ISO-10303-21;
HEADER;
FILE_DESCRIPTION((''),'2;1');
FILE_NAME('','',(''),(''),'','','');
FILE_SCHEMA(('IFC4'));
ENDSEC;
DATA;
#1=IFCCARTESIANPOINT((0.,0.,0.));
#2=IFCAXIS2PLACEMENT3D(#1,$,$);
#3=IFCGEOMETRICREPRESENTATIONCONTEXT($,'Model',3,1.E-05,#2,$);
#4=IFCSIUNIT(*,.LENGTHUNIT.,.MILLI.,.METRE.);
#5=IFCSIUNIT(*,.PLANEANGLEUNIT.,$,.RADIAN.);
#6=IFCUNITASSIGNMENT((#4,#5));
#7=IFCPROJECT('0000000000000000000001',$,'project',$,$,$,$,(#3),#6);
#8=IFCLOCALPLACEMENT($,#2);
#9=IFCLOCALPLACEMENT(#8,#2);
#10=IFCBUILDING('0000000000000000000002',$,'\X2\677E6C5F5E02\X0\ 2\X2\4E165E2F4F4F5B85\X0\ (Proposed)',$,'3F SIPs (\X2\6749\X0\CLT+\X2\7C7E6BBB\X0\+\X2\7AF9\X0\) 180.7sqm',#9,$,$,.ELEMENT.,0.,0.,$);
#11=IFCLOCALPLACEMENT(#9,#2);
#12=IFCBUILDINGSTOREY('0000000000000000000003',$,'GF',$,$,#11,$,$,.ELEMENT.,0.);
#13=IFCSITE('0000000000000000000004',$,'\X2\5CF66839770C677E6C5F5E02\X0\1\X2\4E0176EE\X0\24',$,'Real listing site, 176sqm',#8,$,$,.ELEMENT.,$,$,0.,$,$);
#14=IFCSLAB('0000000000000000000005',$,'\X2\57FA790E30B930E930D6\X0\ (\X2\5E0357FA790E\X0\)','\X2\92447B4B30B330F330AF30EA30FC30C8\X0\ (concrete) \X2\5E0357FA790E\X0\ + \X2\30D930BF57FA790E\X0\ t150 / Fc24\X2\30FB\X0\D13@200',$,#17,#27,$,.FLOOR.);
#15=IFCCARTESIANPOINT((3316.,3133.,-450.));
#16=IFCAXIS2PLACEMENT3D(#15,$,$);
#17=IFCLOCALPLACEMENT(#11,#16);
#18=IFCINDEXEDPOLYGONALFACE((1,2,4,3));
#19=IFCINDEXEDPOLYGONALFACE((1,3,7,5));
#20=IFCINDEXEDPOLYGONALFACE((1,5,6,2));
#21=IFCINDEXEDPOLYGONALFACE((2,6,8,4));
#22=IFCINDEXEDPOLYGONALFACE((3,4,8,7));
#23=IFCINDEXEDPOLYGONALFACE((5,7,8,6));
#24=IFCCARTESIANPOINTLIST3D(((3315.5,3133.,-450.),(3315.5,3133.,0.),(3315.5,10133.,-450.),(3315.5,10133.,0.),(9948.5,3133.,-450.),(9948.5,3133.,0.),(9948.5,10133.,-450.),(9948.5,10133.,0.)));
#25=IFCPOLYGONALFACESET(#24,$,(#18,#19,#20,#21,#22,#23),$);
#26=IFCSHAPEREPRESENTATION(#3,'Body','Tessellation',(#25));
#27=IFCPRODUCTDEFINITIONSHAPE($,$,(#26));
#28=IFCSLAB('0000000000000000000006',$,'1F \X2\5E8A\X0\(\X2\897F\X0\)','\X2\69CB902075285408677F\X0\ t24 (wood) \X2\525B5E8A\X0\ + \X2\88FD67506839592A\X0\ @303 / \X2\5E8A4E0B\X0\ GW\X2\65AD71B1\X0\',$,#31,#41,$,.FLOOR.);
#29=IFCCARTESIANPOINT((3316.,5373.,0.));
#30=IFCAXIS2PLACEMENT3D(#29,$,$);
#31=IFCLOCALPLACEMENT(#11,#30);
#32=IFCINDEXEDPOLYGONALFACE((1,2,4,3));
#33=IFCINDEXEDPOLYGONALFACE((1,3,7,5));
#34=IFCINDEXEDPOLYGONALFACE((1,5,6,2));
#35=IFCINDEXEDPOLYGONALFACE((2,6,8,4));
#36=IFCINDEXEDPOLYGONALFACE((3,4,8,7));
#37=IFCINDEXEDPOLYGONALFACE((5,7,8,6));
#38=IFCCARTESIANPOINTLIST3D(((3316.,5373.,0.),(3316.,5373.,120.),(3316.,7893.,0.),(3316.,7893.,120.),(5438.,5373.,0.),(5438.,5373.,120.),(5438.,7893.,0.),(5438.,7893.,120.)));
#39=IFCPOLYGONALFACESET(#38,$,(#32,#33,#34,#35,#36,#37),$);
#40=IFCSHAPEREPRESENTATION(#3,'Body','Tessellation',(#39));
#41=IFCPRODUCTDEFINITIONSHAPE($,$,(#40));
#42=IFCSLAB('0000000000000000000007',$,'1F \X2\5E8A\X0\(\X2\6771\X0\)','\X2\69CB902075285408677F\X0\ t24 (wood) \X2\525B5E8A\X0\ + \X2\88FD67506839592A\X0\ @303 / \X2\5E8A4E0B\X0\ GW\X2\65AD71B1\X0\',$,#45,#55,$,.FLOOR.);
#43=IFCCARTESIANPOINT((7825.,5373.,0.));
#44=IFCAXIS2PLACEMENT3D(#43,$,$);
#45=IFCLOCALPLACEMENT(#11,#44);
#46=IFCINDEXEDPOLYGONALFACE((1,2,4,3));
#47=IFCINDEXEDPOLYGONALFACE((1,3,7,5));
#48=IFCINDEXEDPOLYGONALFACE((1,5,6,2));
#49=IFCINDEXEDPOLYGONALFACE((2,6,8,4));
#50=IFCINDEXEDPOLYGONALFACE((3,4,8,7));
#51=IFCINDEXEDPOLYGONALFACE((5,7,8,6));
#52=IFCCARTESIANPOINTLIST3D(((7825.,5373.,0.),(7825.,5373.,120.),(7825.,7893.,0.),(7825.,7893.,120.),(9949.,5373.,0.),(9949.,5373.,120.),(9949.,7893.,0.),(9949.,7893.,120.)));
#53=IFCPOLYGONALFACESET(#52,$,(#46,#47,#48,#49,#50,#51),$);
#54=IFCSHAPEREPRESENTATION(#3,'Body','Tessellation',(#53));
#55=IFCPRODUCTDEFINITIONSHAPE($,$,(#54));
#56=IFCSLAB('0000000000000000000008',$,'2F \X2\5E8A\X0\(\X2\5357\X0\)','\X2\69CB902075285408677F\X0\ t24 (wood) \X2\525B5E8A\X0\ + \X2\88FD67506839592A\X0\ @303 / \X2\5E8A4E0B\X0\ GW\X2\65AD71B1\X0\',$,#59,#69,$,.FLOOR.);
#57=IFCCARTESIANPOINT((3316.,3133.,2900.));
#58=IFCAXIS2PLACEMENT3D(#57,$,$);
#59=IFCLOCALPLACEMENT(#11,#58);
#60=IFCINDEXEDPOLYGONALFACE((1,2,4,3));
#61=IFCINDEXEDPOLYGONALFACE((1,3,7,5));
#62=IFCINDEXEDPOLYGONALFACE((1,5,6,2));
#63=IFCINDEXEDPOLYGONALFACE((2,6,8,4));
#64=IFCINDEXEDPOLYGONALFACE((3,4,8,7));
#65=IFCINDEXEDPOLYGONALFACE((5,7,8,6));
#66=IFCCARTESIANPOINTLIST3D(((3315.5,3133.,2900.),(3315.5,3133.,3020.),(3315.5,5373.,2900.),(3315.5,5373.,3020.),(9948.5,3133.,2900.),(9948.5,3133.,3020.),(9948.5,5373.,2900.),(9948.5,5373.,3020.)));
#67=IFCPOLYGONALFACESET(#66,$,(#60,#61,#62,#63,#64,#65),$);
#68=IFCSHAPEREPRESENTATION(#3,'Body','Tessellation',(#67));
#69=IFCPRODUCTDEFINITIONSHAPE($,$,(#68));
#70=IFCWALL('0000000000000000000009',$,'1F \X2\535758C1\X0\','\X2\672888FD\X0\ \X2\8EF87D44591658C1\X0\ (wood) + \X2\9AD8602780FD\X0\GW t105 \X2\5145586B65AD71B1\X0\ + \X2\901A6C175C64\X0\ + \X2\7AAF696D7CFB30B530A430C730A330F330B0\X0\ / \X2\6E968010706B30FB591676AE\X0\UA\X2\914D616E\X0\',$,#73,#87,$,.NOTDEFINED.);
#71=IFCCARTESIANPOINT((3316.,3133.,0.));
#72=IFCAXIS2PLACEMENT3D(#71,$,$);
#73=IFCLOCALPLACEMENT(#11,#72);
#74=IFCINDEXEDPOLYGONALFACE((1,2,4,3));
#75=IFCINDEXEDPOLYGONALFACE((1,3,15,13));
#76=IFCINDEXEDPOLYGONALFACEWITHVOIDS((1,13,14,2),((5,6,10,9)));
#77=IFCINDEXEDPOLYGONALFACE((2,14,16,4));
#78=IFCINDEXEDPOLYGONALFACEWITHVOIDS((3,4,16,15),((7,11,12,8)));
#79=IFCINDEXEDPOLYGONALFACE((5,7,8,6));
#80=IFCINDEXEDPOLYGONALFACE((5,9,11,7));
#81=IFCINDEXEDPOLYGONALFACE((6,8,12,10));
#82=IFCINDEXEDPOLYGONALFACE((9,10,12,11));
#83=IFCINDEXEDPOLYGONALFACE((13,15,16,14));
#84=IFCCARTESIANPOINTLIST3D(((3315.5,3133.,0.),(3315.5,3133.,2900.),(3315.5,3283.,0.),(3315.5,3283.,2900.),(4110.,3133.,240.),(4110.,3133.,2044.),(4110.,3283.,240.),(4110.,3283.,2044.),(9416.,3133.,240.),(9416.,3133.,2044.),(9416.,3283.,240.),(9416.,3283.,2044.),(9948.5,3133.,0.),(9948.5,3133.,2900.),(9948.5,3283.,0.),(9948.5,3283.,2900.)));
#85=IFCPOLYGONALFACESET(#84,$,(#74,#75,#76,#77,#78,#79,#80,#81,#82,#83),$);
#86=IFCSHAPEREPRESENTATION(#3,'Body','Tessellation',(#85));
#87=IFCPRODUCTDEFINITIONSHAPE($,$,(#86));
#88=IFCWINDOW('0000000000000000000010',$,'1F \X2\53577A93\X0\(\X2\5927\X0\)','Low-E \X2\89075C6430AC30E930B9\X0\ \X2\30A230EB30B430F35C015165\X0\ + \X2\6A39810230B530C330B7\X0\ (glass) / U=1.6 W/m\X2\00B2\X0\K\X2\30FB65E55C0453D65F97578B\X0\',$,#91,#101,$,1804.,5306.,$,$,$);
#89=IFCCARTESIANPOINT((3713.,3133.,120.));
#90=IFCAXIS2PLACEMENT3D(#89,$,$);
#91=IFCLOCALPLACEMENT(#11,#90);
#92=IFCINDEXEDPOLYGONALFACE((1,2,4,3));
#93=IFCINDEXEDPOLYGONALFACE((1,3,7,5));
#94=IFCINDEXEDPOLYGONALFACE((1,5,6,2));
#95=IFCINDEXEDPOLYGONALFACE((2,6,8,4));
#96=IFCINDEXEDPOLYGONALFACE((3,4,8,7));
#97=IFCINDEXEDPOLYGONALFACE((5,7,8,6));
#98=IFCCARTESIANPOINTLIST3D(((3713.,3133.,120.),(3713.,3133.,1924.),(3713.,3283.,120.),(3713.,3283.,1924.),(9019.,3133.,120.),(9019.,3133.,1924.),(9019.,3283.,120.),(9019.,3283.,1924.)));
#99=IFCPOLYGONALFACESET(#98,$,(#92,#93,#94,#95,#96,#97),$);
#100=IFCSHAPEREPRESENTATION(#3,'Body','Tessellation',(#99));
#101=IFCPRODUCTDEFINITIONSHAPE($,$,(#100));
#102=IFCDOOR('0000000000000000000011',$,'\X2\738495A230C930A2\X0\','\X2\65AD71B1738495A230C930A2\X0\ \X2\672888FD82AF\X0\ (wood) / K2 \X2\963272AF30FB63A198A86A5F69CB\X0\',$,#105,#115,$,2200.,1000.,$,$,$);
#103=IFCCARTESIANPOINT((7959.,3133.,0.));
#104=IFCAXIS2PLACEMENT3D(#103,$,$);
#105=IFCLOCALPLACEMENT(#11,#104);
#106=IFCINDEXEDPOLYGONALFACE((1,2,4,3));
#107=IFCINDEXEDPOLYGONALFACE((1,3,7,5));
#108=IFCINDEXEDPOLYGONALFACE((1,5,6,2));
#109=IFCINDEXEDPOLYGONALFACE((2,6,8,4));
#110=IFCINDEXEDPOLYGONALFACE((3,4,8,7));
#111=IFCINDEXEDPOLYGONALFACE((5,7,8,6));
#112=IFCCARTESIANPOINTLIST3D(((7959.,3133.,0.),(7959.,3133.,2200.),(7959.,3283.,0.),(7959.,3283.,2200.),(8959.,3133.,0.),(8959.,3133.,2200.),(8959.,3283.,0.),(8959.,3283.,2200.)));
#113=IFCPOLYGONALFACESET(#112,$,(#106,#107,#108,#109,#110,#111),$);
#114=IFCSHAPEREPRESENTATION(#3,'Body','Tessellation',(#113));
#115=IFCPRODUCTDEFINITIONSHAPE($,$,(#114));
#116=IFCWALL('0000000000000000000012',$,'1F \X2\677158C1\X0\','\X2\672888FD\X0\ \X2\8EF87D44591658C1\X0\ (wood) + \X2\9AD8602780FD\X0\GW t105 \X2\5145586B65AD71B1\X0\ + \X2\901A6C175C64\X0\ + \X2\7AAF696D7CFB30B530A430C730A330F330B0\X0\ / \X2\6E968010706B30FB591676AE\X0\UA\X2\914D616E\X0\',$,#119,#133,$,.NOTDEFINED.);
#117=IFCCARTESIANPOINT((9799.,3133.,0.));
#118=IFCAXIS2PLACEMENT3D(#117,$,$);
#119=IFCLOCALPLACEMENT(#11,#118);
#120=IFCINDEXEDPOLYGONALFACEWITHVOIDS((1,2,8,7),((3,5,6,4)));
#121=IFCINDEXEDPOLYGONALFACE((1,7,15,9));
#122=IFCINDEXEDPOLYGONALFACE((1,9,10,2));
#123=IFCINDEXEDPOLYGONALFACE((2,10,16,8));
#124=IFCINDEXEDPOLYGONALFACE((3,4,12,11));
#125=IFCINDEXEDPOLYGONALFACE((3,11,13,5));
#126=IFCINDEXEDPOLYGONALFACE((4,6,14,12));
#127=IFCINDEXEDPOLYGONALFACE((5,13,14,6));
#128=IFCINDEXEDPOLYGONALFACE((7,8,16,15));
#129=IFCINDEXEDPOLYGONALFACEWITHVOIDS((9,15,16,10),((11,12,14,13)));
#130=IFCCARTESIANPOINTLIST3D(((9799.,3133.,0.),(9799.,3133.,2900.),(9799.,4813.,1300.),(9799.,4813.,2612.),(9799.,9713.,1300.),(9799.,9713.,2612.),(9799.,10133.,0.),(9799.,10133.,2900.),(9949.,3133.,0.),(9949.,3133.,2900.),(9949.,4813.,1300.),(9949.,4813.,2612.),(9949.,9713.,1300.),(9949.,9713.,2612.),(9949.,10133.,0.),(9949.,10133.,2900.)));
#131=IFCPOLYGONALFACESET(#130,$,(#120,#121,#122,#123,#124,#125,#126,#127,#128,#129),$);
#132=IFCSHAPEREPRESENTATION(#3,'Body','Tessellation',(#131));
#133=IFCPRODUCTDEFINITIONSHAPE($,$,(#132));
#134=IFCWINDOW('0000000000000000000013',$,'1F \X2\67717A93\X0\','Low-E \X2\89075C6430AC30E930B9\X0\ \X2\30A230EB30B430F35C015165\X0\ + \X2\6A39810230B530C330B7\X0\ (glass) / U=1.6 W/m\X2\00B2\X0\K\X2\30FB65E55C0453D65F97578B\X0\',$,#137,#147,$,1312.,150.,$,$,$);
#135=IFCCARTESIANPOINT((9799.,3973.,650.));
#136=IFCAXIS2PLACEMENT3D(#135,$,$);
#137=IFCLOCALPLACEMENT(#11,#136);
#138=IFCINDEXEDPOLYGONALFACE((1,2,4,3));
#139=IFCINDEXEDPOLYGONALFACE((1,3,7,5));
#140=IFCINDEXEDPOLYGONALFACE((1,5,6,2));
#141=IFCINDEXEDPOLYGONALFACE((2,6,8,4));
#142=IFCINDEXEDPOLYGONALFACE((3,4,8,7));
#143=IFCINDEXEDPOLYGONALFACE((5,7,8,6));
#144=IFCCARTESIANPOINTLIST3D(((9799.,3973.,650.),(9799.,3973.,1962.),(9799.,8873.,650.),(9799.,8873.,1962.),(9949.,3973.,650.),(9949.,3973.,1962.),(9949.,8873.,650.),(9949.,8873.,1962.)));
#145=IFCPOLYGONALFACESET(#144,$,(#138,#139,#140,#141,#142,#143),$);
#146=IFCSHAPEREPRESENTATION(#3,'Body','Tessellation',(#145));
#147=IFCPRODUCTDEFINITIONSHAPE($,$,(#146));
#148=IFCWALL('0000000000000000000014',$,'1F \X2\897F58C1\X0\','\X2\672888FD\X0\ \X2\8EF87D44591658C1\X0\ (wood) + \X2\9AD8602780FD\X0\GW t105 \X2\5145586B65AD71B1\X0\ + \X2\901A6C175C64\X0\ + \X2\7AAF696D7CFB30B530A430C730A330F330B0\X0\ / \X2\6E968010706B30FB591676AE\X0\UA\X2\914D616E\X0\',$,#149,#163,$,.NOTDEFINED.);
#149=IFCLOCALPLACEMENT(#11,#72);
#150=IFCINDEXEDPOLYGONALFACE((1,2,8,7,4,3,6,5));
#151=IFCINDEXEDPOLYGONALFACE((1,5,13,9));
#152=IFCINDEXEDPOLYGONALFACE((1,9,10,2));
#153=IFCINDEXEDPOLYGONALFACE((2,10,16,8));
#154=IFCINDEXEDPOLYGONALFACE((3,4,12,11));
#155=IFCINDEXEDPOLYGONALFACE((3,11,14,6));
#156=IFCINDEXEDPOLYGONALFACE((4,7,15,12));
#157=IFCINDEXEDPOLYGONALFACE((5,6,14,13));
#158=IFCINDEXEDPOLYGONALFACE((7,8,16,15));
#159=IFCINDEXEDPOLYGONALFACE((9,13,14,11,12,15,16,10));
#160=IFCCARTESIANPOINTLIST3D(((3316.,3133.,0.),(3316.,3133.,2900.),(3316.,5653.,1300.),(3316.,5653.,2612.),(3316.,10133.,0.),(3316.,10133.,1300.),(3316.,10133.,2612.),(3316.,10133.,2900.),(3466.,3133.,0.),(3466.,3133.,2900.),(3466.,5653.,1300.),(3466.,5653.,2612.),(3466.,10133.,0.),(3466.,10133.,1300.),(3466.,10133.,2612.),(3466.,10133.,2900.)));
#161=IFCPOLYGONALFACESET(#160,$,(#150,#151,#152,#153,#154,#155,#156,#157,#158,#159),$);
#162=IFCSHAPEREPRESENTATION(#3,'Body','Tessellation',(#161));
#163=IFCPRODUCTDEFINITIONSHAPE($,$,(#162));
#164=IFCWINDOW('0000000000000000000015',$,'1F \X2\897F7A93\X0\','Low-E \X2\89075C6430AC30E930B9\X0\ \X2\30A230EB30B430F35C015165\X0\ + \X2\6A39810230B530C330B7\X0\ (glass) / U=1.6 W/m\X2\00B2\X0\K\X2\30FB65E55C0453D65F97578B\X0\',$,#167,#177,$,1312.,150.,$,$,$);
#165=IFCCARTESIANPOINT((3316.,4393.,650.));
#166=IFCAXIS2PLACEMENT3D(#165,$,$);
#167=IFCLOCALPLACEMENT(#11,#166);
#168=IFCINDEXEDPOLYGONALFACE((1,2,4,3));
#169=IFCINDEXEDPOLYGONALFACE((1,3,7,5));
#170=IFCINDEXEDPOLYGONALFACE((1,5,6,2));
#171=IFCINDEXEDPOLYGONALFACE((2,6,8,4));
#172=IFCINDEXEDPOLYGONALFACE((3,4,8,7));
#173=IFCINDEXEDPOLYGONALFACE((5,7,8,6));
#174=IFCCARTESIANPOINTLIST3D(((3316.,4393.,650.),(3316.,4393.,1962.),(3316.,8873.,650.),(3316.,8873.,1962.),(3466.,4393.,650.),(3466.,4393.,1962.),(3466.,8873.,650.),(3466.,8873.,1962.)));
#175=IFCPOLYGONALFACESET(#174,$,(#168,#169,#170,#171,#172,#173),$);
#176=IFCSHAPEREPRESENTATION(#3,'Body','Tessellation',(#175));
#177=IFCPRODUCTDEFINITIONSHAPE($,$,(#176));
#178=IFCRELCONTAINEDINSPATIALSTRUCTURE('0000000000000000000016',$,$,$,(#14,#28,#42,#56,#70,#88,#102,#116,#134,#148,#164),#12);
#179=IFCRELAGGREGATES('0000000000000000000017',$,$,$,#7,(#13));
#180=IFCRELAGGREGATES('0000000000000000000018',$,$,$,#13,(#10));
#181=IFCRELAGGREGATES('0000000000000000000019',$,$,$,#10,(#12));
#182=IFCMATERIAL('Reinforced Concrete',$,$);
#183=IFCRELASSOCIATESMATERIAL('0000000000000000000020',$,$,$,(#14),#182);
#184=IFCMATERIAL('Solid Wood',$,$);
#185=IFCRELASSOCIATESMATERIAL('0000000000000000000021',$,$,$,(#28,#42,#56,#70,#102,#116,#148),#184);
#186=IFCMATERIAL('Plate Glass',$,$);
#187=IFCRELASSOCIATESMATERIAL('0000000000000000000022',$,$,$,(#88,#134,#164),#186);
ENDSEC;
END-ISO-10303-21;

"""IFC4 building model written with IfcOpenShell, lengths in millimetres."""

from ifc_helpers import new_model, si_unit, frame, frame_2d, origin, place, context, project, spatial, rectangle, extrude, material, element, fill, save


model = new_model("IFC4")

# Units and contexts
model_context = context("Model", 3, precision=1e-05, world=origin())
ifc_project = project(units=[si_unit("LENGTHUNIT", "METRE", prefix="MILLI"), si_unit("PLANEANGLEUNIT", "RADIAN")], contexts=[model_context])

# Site, building, storey
site_placement = place(None, origin())
site = spatial("IfcSite", under=ifc_project, at=site_placement, Name="島根県松江市1丁目24", ObjectType="Real listing site, 176sqm", CompositionType="ELEMENT", RefElevation=0.0)
building_placement = place(site_placement, origin())
building = spatial("IfcBuilding", under=site, at=building_placement, Name="松江市 2世帯住宅 (Proposed)", ObjectType="3F SIPs (杉CLT+籾殻+竹) 180.7sqm", CompositionType="ELEMENT", ElevationOfRefHeight=0.0, ElevationOfTerrain=0.0)
storey_placement = place(building_placement, origin())
storey = spatial("IfcBuildingStorey", under=building, at=storey_placement, Name="GF", CompositionType="ELEMENT", Elevation=0.0)

# Slabs
ifc_material_1 = material(Name="Reinforced Concrete")
slab_1_placement = place(storey_placement, frame((3316.0, 3133.0, -450.0)))
element("IfcSlab", 1, at=slab_1_placement, inside=storey, material=ifc_material_1, Name="基礎スラブ (布基礎)", Description="鉄筋コンクリート (concrete) 布基礎 + ベタ基礎 t150 / Fc24・D13@200", PredefinedType="FLOOR", context=model_context, shape_type="SweptSolid", body=[
    extrude(rectangle(XDim=6633.0, YDim=7000.0, at=frame_2d((3316.0, 3500.0))), frame((3316.0, 3133.0, -450.0)), (0.0, 0.0, 1.0), 450.0),
])
ifc_material_2 = material(Name="Solid Wood")
slab_2_placement = place(storey_placement, frame((3316.0, 5373.0, 0.0)))
element("IfcSlab", 2, at=slab_2_placement, inside=storey, material=ifc_material_2, Name="1F 床(西)", Description="構造用合板 t24 (wood) 剛床 + 製材根太 @303 / 床下 GW断熱", PredefinedType="FLOOR", context=model_context, shape_type="SweptSolid", body=[
    extrude(rectangle(XDim=2122.0, YDim=2520.0, at=frame_2d((1061.0, 1260.0))), frame((3316.0, 5373.0, 0.0)), (0.0, 0.0, 1.0), 120.0),
])
slab_3_placement = place(storey_placement, frame((7825.0, 5373.0, 0.0)))
element("IfcSlab", 3, at=slab_3_placement, inside=storey, material=ifc_material_2, Name="1F 床(東)", Description="構造用合板 t24 (wood) 剛床 + 製材根太 @303 / 床下 GW断熱", PredefinedType="FLOOR", context=model_context, shape_type="SweptSolid", body=[
    extrude(rectangle(XDim=2124.0, YDim=2520.0, at=frame_2d((1062.0, 1260.0))), frame((7825.0, 5373.0, 0.0)), (0.0, 0.0, 1.0), 120.0),
])
slab_4_placement = place(storey_placement, frame((3316.0, 3133.0, 2900.0)))
element("IfcSlab", 4, at=slab_4_placement, inside=storey, material=ifc_material_2, Name="2F 床(南)", Description="構造用合板 t24 (wood) 剛床 + 製材根太 @303 / 床下 GW断熱", PredefinedType="FLOOR", context=model_context, shape_type="SweptSolid", body=[
    extrude(rectangle(XDim=6633.0, YDim=2240.0, at=frame_2d((3316.0, 1120.0))), frame((3316.0, 3133.0, 2900.0)), (0.0, 0.0, 1.0), 120.0),
])

# Wall, openings, window, door
wall_1_placement = place(storey_placement, frame((3316.0, 3133.0, 0.0)))
wall_1 = element("IfcWall", 5, at=wall_1_placement, inside=storey, material=ifc_material_2, Name="1F 南壁", Description="木製 軸組外壁 (wood) + 高性能GW t105 充填断熱 + 通気層 + 窯業系サイディング / 準耐火・外皮UA配慮", PredefinedType="NOTDEFINED", context=model_context, shape_type="SweptSolid", body=[
    extrude(rectangle(XDim=6633.0, YDim=150.0, at=frame_2d((3316.0, 75.0))), frame((3316.0, 3133.0, 0.0)), (0.0, 0.0, 1.0), 2900.0),
])
opening_1_placement = place(storey_placement, frame((3713.0, 3133.0, 120.0)))
opening_1 = element("IfcOpeningElement", 6, at=opening_1_placement, cuts=wall_1, PredefinedType="NOTDEFINED", context=model_context, shape_type="SweptSolid", body=[
    extrude(rectangle(XDim=5306.0, YDim=150.0, at=frame_2d((2653.0, 75.0))), frame((3713.0, 3133.0, 120.0)), (0.0, 0.0, 1.0), 1804.0),
])
opening_2_placement = place(storey_placement, frame((7959.0, 3133.0, 0.0)))
opening_2 = element("IfcOpeningElement", 7, at=opening_2_placement, cuts=wall_1, PredefinedType="NOTDEFINED", context=model_context, shape_type="SweptSolid", body=[
    extrude(rectangle(XDim=1000.0, YDim=150.0, at=frame_2d((500.0, 75.0))), frame((7959.0, 3133.0, 0.0)), (0.0, 0.0, 1.0), 2200.0),
])
ifc_material_3 = material(Name="Plate Glass")
window_1_placement = place(storey_placement, frame((3713.0, 3133.0, 120.0)))
window_1 = element("IfcWindow", 8, at=window_1_placement, inside=storey, material=ifc_material_3, Name="1F 南窓(大)", Description="Low-E 複層ガラス アルゴン封入 + 樹脂サッシ (glass) / U=1.6 W/m²K・日射取得型", OverallHeight=1804.0, OverallWidth=5306.0, context=model_context, shape_type="SweptSolid", body=[
    extrude(rectangle(XDim=5306.0, YDim=150.0, at=frame_2d((2653.0, 75.0))), frame((3713.0, 3133.0, 120.0)), (0.0, 0.0, 1.0), 1804.0),
])
fill(opening_1, window_1)
door_placement = place(storey_placement, frame((7959.0, 3133.0, 0.0)))
door = element("IfcDoor", 9, at=door_placement, inside=storey, material=ifc_material_2, Name="玄関ドア", Description="断熱玄関ドア 木製芯 (wood) / K2 防犯・採風機構", OverallHeight=2200.0, OverallWidth=1000.0, context=model_context, shape_type="SweptSolid", body=[
    extrude(rectangle(XDim=1000.0, YDim=150.0, at=frame_2d((500.0, 75.0))), frame((7959.0, 3133.0, 0.0)), (0.0, 0.0, 1.0), 2200.0),
])
fill(opening_2, door)

# Walls, openings, windows
wall_2_placement = place(storey_placement, frame((9799.0, 3133.0, 0.0)))
wall_2 = element("IfcWall", 10, at=wall_2_placement, inside=storey, material=ifc_material_2, Name="1F 東壁", Description="木製 軸組外壁 (wood) + 高性能GW t105 充填断熱 + 通気層 + 窯業系サイディング / 準耐火・外皮UA配慮", PredefinedType="NOTDEFINED", context=model_context, shape_type="SweptSolid", body=[
    extrude(rectangle(XDim=150.0, YDim=7000.0, at=frame_2d((75.0, 3500.0))), frame((9799.0, 3133.0, 0.0)), (0.0, 0.0, 1.0), 2900.0),
])
opening_3_placement = place(storey_placement, frame((9799.0, 3973.0, 650.0)))
opening_3 = element("IfcOpeningElement", 11, at=opening_3_placement, cuts=wall_2, PredefinedType="NOTDEFINED", context=model_context, shape_type="SweptSolid", body=[
    extrude(rectangle(XDim=150.0, YDim=4900.0, at=frame_2d((75.0, 2450.0))), frame((9799.0, 3973.0, 650.0)), (0.0, 0.0, 1.0), 1312.0),
])
window_2_placement = place(storey_placement, frame((9799.0, 3973.0, 650.0)))
window_2 = element("IfcWindow", 12, at=window_2_placement, inside=storey, material=ifc_material_3, Name="1F 東窓", Description="Low-E 複層ガラス アルゴン封入 + 樹脂サッシ (glass) / U=1.6 W/m²K・日射取得型", OverallHeight=1312.0, OverallWidth=150.0, context=model_context, shape_type="SweptSolid", body=[
    extrude(rectangle(XDim=150.0, YDim=4900.0, at=frame_2d((75.0, 2450.0))), frame((9799.0, 3973.0, 650.0)), (0.0, 0.0, 1.0), 1312.0),
])
fill(opening_3, window_2)
wall_3_placement = place(storey_placement, frame((3316.0, 3133.0, 0.0)))
wall_3 = element("IfcWall", 13, at=wall_3_placement, inside=storey, material=ifc_material_2, Name="1F 西壁", Description="木製 軸組外壁 (wood) + 高性能GW t105 充填断熱 + 通気層 + 窯業系サイディング / 準耐火・外皮UA配慮", PredefinedType="NOTDEFINED", context=model_context, shape_type="SweptSolid", body=[
    extrude(rectangle(XDim=150.0, YDim=7000.0, at=frame_2d((75.0, 3500.0))), frame((3316.0, 3133.0, 0.0)), (0.0, 0.0, 1.0), 2900.0),
])
opening_4_placement = place(storey_placement, frame((3316.0, 4393.0, 650.0)))
opening_4 = element("IfcOpeningElement", 14, at=opening_4_placement, cuts=wall_3, PredefinedType="NOTDEFINED", context=model_context, shape_type="SweptSolid", body=[
    extrude(rectangle(XDim=150.0, YDim=4480.0, at=frame_2d((75.0, 2240.0))), frame((3316.0, 4393.0, 650.0)), (0.0, 0.0, 1.0), 1312.0),
])
window_3_placement = place(storey_placement, frame((3316.0, 4393.0, 650.0)))
window_3 = element("IfcWindow", 15, at=window_3_placement, inside=storey, material=ifc_material_3, Name="1F 西窓", Description="Low-E 複層ガラス アルゴン封入 + 樹脂サッシ (glass) / U=1.6 W/m²K・日射取得型", OverallHeight=1312.0, OverallWidth=150.0, context=model_context, shape_type="SweptSolid", body=[
    extrude(rectangle(XDim=150.0, YDim=4480.0, at=frame_2d((75.0, 2240.0))), frame((3316.0, 4393.0, 650.0)), (0.0, 0.0, 1.0), 1312.0),
])
fill(opening_4, window_3)

save(model, "model.ifc")
